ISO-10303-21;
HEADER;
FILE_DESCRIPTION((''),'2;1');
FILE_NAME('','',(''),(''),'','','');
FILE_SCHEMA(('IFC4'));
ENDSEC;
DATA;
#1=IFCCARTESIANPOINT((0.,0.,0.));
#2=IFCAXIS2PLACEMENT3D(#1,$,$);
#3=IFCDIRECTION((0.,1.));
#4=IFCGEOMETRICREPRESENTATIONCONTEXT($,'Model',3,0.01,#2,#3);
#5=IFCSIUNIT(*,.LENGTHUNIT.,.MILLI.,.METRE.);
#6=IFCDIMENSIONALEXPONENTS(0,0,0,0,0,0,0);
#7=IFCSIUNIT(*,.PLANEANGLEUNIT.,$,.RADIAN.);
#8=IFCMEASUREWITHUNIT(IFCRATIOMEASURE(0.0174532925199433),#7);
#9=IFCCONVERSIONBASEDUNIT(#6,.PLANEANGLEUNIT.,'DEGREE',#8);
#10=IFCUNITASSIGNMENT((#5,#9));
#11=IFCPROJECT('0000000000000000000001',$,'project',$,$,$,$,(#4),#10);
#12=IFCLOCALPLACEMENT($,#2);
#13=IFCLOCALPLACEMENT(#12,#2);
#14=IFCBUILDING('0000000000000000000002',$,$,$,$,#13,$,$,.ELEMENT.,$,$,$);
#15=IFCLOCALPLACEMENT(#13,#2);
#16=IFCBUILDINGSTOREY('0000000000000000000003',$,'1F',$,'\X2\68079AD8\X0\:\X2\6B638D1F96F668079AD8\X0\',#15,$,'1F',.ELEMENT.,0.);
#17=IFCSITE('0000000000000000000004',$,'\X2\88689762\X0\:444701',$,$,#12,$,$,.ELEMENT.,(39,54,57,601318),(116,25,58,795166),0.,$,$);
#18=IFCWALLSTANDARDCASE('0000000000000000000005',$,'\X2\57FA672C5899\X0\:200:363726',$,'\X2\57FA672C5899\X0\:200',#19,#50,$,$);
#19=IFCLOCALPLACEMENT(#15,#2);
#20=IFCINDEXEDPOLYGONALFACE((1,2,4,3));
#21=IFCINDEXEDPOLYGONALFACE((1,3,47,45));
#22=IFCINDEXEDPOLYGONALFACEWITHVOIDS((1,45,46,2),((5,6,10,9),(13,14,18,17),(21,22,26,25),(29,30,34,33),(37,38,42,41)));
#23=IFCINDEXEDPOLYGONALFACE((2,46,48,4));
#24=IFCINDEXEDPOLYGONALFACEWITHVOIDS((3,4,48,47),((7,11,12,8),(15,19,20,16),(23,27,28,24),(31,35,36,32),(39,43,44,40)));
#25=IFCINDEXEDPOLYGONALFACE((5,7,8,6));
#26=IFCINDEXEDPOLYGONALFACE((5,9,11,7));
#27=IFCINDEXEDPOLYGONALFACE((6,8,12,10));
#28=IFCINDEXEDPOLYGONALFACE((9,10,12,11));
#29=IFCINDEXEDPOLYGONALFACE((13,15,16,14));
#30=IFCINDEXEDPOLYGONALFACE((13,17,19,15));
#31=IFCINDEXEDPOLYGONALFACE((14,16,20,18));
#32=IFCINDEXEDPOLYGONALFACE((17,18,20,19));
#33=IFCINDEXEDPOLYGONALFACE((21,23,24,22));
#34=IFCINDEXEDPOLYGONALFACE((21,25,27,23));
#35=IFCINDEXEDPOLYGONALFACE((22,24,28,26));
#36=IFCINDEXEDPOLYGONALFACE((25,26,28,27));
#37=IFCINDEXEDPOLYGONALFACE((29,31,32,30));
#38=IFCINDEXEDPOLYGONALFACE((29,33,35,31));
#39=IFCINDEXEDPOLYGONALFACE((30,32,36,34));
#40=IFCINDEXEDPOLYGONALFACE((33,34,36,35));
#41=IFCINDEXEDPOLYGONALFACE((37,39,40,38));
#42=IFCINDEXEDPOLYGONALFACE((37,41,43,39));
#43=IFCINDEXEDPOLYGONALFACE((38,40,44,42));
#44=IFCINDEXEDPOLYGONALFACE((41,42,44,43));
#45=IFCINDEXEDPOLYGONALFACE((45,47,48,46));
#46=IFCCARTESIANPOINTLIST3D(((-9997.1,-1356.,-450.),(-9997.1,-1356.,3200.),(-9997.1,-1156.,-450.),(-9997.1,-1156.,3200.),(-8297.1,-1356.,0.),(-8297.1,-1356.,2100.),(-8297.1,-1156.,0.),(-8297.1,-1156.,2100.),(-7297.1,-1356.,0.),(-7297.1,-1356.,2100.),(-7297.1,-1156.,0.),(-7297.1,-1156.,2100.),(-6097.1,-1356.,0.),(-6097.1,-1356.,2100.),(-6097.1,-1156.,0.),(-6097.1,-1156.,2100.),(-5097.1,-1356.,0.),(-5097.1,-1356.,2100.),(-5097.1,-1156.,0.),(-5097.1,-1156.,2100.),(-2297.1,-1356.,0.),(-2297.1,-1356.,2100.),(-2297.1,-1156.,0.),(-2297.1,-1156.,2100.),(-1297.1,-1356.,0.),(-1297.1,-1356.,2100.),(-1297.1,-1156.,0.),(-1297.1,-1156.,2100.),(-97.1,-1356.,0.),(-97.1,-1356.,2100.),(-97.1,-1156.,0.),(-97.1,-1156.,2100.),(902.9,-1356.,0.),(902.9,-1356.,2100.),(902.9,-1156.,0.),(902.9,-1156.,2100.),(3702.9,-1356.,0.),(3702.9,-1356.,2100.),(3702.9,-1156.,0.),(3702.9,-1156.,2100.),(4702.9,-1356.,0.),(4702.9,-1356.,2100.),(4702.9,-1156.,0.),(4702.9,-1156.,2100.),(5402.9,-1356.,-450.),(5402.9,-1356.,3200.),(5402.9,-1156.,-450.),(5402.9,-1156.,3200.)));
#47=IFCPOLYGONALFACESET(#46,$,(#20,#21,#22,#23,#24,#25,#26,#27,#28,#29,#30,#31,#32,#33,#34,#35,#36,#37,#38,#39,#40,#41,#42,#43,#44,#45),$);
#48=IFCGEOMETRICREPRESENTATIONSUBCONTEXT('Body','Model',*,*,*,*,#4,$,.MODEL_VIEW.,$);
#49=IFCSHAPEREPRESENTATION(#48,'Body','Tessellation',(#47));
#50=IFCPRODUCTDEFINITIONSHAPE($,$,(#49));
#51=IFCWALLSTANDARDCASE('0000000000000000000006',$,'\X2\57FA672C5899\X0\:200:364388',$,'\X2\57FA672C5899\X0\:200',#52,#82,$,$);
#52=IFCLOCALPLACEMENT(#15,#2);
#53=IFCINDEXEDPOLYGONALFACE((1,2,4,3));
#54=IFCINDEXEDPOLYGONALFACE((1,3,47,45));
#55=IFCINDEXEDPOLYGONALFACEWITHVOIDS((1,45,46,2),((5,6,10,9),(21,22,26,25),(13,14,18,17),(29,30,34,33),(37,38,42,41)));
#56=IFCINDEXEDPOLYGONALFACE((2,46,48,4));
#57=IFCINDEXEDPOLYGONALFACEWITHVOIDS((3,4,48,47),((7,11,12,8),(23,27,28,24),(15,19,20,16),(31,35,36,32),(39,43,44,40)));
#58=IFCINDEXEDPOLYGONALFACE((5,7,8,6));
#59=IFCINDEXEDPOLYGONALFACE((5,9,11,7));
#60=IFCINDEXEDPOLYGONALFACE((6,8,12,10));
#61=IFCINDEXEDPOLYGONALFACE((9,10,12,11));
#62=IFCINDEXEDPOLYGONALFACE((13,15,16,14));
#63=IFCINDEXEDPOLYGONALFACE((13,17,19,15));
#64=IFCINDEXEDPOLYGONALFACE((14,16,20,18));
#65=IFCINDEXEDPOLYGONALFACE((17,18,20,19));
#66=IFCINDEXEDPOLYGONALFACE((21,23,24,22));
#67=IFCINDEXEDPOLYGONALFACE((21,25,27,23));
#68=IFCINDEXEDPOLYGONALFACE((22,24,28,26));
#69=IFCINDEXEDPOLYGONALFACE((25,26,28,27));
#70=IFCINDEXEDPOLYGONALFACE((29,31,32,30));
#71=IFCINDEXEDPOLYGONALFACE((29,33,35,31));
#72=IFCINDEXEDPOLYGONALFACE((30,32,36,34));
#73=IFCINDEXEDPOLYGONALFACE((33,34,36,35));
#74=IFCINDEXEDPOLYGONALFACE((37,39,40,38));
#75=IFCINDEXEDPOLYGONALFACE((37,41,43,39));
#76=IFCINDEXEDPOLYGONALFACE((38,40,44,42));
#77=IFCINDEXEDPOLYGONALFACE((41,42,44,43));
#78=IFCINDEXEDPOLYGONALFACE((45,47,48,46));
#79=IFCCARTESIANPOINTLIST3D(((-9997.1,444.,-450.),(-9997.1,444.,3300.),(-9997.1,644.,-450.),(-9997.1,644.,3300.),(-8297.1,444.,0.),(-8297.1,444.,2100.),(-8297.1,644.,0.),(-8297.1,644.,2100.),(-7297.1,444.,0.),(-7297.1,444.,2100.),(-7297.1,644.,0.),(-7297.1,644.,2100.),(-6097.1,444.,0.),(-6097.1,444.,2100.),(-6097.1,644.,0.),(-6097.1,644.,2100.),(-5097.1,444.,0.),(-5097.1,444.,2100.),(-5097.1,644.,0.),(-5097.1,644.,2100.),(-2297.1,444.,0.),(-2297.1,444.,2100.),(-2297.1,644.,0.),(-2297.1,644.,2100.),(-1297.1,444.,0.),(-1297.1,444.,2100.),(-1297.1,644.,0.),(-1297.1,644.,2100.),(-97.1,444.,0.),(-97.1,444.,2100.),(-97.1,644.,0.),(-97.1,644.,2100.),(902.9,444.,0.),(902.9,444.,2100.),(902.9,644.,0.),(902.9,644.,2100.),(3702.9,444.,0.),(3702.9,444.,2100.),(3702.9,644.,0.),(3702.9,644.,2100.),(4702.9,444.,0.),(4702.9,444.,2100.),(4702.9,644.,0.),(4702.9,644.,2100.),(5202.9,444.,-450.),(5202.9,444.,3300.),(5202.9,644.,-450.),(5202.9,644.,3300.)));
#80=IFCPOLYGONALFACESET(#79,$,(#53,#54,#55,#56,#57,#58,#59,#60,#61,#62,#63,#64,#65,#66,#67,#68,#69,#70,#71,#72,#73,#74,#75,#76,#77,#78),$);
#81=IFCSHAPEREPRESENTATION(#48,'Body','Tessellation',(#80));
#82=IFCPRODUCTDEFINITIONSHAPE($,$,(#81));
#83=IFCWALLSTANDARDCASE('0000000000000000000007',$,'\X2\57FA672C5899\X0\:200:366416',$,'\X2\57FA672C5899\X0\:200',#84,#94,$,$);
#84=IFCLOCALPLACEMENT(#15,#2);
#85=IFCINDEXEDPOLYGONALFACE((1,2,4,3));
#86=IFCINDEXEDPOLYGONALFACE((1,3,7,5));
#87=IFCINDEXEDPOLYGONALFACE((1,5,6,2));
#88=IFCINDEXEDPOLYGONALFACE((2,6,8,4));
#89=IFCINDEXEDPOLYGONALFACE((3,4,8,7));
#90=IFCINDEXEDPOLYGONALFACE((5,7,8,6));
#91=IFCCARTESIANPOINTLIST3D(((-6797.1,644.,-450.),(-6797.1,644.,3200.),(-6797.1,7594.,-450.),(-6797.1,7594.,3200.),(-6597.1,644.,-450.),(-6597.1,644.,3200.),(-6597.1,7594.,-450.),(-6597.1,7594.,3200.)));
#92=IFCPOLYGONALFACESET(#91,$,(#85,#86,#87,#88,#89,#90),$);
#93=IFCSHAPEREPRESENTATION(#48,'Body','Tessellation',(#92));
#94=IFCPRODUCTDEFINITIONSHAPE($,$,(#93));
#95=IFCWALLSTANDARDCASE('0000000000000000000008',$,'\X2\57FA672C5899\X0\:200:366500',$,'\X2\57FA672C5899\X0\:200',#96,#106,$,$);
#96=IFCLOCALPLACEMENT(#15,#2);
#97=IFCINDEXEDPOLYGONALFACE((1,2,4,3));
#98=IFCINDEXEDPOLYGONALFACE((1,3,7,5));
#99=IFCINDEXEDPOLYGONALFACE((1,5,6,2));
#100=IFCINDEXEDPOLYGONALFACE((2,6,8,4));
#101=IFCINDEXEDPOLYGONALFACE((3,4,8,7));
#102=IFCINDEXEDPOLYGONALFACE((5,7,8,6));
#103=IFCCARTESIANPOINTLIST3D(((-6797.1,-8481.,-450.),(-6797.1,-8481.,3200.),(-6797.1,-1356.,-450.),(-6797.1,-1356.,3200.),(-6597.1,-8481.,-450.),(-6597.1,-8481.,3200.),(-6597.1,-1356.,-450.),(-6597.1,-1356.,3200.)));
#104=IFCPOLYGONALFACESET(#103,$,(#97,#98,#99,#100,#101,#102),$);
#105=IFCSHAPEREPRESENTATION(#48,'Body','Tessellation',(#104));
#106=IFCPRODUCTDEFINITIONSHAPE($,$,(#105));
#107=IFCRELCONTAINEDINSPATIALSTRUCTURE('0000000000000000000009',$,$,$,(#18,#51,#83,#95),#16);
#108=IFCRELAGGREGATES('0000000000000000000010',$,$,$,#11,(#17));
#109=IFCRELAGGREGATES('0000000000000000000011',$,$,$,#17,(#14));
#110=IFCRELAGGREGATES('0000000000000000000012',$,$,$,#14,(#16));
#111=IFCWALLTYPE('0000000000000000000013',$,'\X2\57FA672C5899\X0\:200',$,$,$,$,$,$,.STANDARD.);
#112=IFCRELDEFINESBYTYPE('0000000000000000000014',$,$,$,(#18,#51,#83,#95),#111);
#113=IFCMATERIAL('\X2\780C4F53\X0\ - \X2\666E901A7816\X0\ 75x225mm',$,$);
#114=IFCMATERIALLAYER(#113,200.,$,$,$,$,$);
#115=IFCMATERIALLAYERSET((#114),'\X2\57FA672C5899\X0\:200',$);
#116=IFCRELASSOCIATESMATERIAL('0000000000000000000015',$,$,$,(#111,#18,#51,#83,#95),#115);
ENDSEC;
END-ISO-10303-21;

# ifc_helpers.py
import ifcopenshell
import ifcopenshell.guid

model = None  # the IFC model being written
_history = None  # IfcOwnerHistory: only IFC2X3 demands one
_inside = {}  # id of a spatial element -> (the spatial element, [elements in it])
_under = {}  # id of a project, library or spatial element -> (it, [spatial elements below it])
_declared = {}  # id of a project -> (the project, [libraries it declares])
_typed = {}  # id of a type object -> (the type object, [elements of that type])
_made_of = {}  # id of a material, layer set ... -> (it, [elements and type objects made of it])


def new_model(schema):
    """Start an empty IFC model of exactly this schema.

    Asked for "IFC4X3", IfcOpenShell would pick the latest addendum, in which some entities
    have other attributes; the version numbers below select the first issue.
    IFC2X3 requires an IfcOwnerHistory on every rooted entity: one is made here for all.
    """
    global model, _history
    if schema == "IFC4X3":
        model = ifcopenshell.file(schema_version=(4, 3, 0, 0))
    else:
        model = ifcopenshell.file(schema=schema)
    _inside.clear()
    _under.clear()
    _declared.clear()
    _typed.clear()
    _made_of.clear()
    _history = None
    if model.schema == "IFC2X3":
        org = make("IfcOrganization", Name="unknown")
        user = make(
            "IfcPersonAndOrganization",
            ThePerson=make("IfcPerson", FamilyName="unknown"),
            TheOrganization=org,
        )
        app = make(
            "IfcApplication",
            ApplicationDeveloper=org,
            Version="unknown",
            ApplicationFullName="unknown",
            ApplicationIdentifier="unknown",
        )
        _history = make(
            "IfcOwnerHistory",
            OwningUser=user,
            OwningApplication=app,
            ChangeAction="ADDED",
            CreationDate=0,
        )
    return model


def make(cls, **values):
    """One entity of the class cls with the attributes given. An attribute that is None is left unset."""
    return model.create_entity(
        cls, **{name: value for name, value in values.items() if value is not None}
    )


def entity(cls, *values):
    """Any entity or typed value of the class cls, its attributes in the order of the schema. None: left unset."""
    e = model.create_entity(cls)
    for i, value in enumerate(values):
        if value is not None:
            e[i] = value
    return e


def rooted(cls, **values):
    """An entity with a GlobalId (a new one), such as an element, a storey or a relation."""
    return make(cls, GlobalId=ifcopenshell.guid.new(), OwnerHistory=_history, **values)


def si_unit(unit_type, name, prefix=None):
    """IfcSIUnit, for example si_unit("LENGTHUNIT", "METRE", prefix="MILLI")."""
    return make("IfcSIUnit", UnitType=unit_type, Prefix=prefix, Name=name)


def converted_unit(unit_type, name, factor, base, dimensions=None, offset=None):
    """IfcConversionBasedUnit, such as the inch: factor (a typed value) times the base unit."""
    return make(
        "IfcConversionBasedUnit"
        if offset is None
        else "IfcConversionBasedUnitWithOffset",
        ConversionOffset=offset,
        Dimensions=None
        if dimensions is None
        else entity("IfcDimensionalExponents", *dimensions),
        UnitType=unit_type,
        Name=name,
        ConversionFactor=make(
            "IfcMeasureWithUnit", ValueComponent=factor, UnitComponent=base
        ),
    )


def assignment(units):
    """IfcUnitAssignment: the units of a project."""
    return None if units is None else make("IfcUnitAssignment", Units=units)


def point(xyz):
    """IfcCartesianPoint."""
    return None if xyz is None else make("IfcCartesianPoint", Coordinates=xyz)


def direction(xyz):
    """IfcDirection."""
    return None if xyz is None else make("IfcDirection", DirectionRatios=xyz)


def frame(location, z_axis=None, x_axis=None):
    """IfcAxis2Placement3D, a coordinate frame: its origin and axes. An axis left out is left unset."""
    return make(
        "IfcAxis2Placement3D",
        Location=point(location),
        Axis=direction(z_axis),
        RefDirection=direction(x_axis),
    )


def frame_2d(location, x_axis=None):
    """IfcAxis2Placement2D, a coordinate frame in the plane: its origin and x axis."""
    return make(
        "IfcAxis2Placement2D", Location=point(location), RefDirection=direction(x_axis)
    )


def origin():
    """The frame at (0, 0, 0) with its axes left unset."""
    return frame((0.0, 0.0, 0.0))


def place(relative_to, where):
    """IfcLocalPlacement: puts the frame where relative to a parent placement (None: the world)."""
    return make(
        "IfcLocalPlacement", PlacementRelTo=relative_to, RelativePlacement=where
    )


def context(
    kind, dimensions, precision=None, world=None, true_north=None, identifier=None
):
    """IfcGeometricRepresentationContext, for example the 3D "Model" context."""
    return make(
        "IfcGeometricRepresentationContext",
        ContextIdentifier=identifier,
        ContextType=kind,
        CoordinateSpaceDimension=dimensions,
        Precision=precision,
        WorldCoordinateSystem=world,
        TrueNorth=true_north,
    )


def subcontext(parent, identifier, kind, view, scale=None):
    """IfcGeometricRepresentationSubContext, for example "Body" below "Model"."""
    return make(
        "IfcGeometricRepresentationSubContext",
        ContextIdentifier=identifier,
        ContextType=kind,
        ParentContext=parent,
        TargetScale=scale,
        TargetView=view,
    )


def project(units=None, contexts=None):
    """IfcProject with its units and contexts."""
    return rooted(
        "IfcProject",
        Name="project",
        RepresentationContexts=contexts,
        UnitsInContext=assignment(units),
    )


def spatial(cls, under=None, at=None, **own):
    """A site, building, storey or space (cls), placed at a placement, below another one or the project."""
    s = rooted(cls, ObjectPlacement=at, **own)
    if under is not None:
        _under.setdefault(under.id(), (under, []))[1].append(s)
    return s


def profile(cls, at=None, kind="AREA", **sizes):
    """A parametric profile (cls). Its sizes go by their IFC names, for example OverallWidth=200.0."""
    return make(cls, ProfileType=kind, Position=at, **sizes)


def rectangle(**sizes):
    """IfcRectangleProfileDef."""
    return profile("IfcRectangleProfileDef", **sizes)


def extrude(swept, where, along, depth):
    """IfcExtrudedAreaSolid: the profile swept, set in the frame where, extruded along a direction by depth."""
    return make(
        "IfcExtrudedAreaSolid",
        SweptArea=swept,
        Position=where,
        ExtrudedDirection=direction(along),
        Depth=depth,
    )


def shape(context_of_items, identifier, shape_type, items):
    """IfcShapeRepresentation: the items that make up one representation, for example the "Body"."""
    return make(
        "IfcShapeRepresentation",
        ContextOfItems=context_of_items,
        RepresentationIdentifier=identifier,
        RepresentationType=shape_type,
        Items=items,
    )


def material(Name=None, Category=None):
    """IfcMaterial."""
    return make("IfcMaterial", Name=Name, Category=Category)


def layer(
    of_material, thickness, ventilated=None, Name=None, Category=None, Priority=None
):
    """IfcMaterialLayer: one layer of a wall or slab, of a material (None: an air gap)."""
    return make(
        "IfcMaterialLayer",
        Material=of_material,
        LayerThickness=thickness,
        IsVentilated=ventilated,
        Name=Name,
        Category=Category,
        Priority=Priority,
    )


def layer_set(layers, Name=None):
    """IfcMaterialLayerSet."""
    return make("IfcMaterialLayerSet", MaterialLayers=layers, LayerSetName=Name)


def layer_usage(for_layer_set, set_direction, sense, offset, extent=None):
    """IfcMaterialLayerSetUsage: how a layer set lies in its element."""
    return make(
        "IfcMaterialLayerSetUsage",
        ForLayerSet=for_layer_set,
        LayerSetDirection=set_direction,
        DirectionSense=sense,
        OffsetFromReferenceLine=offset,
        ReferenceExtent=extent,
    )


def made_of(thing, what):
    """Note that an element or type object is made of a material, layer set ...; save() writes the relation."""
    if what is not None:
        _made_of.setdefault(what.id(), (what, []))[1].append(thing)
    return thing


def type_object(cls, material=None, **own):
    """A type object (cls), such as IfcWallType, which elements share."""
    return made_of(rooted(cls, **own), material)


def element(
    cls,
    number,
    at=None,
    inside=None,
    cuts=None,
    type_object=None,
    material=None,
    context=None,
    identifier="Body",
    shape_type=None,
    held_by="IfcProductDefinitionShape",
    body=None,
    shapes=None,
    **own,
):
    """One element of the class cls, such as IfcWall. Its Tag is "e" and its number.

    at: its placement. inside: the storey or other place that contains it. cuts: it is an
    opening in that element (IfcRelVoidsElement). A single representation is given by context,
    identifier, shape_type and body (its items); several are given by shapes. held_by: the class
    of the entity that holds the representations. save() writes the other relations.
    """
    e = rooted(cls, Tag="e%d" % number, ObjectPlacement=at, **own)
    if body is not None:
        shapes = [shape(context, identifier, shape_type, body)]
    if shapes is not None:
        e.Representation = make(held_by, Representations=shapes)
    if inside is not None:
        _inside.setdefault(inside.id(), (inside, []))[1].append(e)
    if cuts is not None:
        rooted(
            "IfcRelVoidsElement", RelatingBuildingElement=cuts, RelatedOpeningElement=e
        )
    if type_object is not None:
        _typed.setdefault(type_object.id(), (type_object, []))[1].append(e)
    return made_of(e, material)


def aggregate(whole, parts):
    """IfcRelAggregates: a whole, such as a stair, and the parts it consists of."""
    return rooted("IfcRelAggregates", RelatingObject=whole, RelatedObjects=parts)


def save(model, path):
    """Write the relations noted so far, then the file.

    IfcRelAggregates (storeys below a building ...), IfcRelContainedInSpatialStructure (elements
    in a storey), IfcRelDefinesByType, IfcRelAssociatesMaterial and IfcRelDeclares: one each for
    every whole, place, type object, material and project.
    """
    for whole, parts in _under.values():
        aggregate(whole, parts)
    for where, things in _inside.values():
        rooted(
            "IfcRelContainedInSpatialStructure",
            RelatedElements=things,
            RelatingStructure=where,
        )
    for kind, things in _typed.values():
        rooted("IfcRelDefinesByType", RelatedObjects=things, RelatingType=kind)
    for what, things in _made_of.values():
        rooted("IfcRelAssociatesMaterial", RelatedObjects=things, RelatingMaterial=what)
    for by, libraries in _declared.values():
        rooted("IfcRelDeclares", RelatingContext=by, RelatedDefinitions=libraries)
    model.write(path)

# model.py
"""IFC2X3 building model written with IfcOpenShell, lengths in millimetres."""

from ifc_helpers import new_model, entity, si_unit, converted_unit, direction, frame, frame_2d, origin, place, context, subcontext, project, spatial, rectangle, extrude, material, layer, layer_set, layer_usage, type_object, element, save


model = new_model("IFC2X3")

# Units and contexts
model_context = context("Model", 3, precision=0.01, world=origin(), true_north=direction((0.0, 1.0)))
body_context = subcontext(model_context, "Body", "Model", "MODEL_VIEW")
ifc_project = project(units=[si_unit("LENGTHUNIT", "METRE", prefix="MILLI"), converted_unit("PLANEANGLEUNIT", "DEGREE", entity("IfcRatioMeasure", 0.0174532925199433), si_unit("PLANEANGLEUNIT", "RADIAN"), dimensions=[0, 0, 0, 0, 0, 0, 0])], contexts=[model_context])

# Site, building, storey
site_placement = place(None, origin())
site = spatial("IfcSite", under=ifc_project, at=site_placement, Name="表面:444701", CompositionType="ELEMENT", RefLatitude=(39, 54, 57, 601318), RefLongitude=(116, 25, 58, 795166), RefElevation=0.0)
building_placement = place(site_placement, origin())
building = spatial("IfcBuilding", under=site, at=building_placement, CompositionType="ELEMENT")
storey_placement = place(building_placement, origin())
storey = spatial("IfcBuildingStorey", under=building, at=storey_placement, Name="1F", ObjectType="标高:正负零标高", LongName="1F", CompositionType="ELEMENT", Elevation=0.0)

# Shared definitions
ifc_material_1 = material(Name="砌体 - 普通砖 75x225mm")

# Walls, openings
ifc_layer_1 = layer(ifc_material_1, 200.0)
ifc_layer_set_1 = layer_set([ifc_layer_1], Name="基本墙:200")
ifc_layer_usage_1 = layer_usage(ifc_layer_set_1, "AXIS2", "NEGATIVE", 100.0)
wall_type_1 = type_object("IfcWallType", Name="基本墙:200", PredefinedType="STANDARD", material=ifc_layer_set_1)
wall_1_placement = place(storey_placement, frame((-9997.1, -1256.0, -450.0)))
wall_1 = element("IfcWallStandardCase", 1, at=wall_1_placement, inside=storey, type_object=wall_type_1, material=ifc_layer_usage_1, Name="基本墙:200:363726", ObjectType="基本墙:200", context=body_context, shape_type="SweptSolid", body=[
    extrude(rectangle(XDim=15400.0, YDim=200.0, at=frame_2d((7700.0, 0.0), x_axis=(-1.0, 0.0))), origin(), (0.0, 0.0, 1.0), 3650.0),
])
opening_1_placement = place(wall_1_placement, frame((2700.0, 100.0, 450.0)))
element("IfcOpeningElement", 2, at=opening_1_placement, cuts=wall_1, ObjectType="Opening", context=body_context, shape_type="SweptSolid", body=[
    extrude(rectangle(XDim=2100.0, YDim=1000.0, at=frame_2d((1050.0, 500.0), x_axis=(1.0, 0.0))), frame((0.0, 0.0, 0.0), z_axis=(0.0, -1.0, 0.0), x_axis=(0.0, 0.0, 1.0)), (0.0, 0.0, 1.0), 200.0),
])
opening_2_placement = place(wall_1_placement, frame((4900.0, 100.0, 450.0)))
element("IfcOpeningElement", 3, at=opening_2_placement, cuts=wall_1, ObjectType="Opening", context=body_context, shape_type="SweptSolid", body=[
    extrude(rectangle(XDim=2100.0, YDim=1000.0, at=frame_2d((1050.0, 500.0), x_axis=(1.0, 0.0))), frame((0.0, 0.0, 0.0), z_axis=(0.0, -1.0, 0.0), x_axis=(0.0, 0.0, 1.0)), (0.0, 0.0, 1.0), 200.0),
])
opening_3_placement = place(wall_1_placement, frame((8700.0, 100.0, 450.0)))
element("IfcOpeningElement", 4, at=opening_3_placement, cuts=wall_1, ObjectType="Opening", context=body_context, shape_type="SweptSolid", body=[
    extrude(rectangle(XDim=2100.0, YDim=1000.0, at=frame_2d((1050.0, 500.0), x_axis=(1.0, 0.0))), frame((0.0, 0.0, 0.0), z_axis=(0.0, -1.0, 0.0), x_axis=(0.0, 0.0, 1.0)), (0.0, 0.0, 1.0), 200.0),
])
opening_4_placement = place(wall_1_placement, frame((10900.0, 100.0, 450.0)))
element("IfcOpeningElement", 5, at=opening_4_placement, cuts=wall_1, ObjectType="Opening", context=body_context, shape_type="SweptSolid", body=[
    extrude(rectangle(XDim=2100.0, YDim=1000.0, at=frame_2d((1050.0, 500.0), x_axis=(1.0, 0.0))), frame((0.0, 0.0, 0.0), z_axis=(0.0, -1.0, 0.0), x_axis=(0.0, 0.0, 1.0)), (0.0, 0.0, 1.0), 200.0),
])
opening_5_placement = place(wall_1_placement, frame((14700.0, 100.0, 450.0)))
element("IfcOpeningElement", 6, at=opening_5_placement, cuts=wall_1, ObjectType="Opening", context=body_context, shape_type="SweptSolid", body=[
    extrude(rectangle(XDim=2100.0, YDim=1000.0, at=frame_2d((1050.0, 500.0), x_axis=(1.0, 0.0))), frame((0.0, 0.0, 0.0), z_axis=(0.0, -1.0, 0.0), x_axis=(0.0, 0.0, 1.0)), (0.0, 0.0, 1.0), 200.0),
])
ifc_layer_usage_2 = layer_usage(ifc_layer_set_1, "AXIS2", "NEGATIVE", 100.0)
wall_2_placement = place(storey_placement, frame((-9997.1, 544.0, -450.0)))
wall_2 = element("IfcWallStandardCase", 7, at=wall_2_placement, inside=storey, type_object=wall_type_1, material=ifc_layer_usage_2, Name="基本墙:200:364388", ObjectType="基本墙:200", context=body_context, shape_type="SweptSolid", body=[
    extrude(rectangle(XDim=15200.0, YDim=200.0, at=frame_2d((7600.0, 0.0), x_axis=(-1.0, 0.0))), origin(), (0.0, 0.0, 1.0), 3750.0),
])
opening_6_placement = place(wall_2_placement, frame((1700.0, -100.0, 450.0)))
element("IfcOpeningElement", 8, at=opening_6_placement, cuts=wall_2, ObjectType="Opening", context=body_context, shape_type="SweptSolid", body=[
    extrude(rectangle(XDim=2100.0, YDim=1000.0, at=frame_2d((1050.0, 500.0), x_axis=(1.0, 0.0))), frame((0.0, 0.0, 0.0), z_axis=(0.0, 1.0, 0.0), x_axis=(0.0, 0.0, 1.0)), (0.0, 0.0, 1.0), 200.0),
])
opening_7_placement = place(wall_2_placement, frame((3900.0, -100.0, 450.0)))
element("IfcOpeningElement", 9, at=opening_7_placement, cuts=wall_2, ObjectType="Opening", context=body_context, shape_type="SweptSolid", body=[
    extrude(rectangle(XDim=2100.0, YDim=1000.0, at=frame_2d((1050.0, 500.0), x_axis=(1.0, 0.0))), frame((0.0, 0.0, 0.0), z_axis=(0.0, 1.0, 0.0), x_axis=(0.0, 0.0, 1.0)), (0.0, 0.0, 1.0), 200.0),
])
opening_8_placement = place(wall_2_placement, frame((7700.0, -100.0, 450.0)))
element("IfcOpeningElement", 10, at=opening_8_placement, cuts=wall_2, ObjectType="Opening", context=body_context, shape_type="SweptSolid", body=[
    extrude(rectangle(XDim=2100.0, YDim=1000.0, at=frame_2d((1050.0, 500.0), x_axis=(1.0, 0.0))), frame((0.0, 0.0, 0.0), z_axis=(0.0, 1.0, 0.0), x_axis=(0.0, 0.0, 1.0)), (0.0, 0.0, 1.0), 200.0),
])
opening_9_placement = place(wall_2_placement, frame((9900.0, -100.0, 450.0)))
element("IfcOpeningElement", 11, at=opening_9_placement, cuts=wall_2, ObjectType="Opening", context=body_context, shape_type="SweptSolid", body=[
    extrude(rectangle(XDim=2100.0, YDim=1000.0, at=frame_2d((1050.0, 500.0), x_axis=(1.0, 0.0))), frame((0.0, 0.0, 0.0), z_axis=(0.0, 1.0, 0.0), x_axis=(0.0, 0.0, 1.0)), (0.0, 0.0, 1.0), 200.0),
])
opening_10_placement = place(wall_2_placement, frame((13700.0, -100.0, 450.0)))
element("IfcOpeningElement", 12, at=opening_10_placement, cuts=wall_2, ObjectType="Opening", context=body_context, shape_type="SweptSolid", body=[
    extrude(rectangle(XDim=2100.0, YDim=1000.0, at=frame_2d((1050.0, 500.0), x_axis=(1.0, 0.0))), frame((0.0, 0.0, 0.0), z_axis=(0.0, 1.0, 0.0), x_axis=(0.0, 0.0, 1.0)), (0.0, 0.0, 1.0), 200.0),
])

# Walls
ifc_layer_usage_3 = layer_usage(ifc_layer_set_1, "AXIS2", "NEGATIVE", 100.0)
wall_3_placement = place(storey_placement, frame((-6697.1, 7594.0, -450.0), z_axis=(0.0, 0.0, 1.0), x_axis=(0.0, -1.0, 0.0)))
element("IfcWallStandardCase", 13, at=wall_3_placement, inside=storey, type_object=wall_type_1, material=ifc_layer_usage_3, Name="基本墙:200:366416", ObjectType="基本墙:200", context=body_context, shape_type="SweptSolid", body=[
    extrude(rectangle(XDim=6950.0, YDim=200.0, at=frame_2d((3475.0, 0.0), x_axis=(-1.0, 0.0))), origin(), (0.0, 0.0, 1.0), 3650.0),
])
ifc_layer_usage_4 = layer_usage(ifc_layer_set_1, "AXIS2", "NEGATIVE", 100.0)
wall_4_placement = place(storey_placement, frame((-6697.1, -1356.0, -450.0), z_axis=(0.0, 0.0, 1.0), x_axis=(0.0, -1.0, 0.0)))
element("IfcWallStandardCase", 14, at=wall_4_placement, inside=storey, type_object=wall_type_1, material=ifc_layer_usage_4, Name="基本墙:200:366500", ObjectType="基本墙:200", context=body_context, shape_type="SweptSolid", body=[
    extrude(rectangle(XDim=7125.0, YDim=200.0, at=frame_2d((3562.5, 0.0), x_axis=(-1.0, 0.0))), origin(), (0.0, 0.0, 1.0), 3650.0),
])

save(model, "model.ifc")
